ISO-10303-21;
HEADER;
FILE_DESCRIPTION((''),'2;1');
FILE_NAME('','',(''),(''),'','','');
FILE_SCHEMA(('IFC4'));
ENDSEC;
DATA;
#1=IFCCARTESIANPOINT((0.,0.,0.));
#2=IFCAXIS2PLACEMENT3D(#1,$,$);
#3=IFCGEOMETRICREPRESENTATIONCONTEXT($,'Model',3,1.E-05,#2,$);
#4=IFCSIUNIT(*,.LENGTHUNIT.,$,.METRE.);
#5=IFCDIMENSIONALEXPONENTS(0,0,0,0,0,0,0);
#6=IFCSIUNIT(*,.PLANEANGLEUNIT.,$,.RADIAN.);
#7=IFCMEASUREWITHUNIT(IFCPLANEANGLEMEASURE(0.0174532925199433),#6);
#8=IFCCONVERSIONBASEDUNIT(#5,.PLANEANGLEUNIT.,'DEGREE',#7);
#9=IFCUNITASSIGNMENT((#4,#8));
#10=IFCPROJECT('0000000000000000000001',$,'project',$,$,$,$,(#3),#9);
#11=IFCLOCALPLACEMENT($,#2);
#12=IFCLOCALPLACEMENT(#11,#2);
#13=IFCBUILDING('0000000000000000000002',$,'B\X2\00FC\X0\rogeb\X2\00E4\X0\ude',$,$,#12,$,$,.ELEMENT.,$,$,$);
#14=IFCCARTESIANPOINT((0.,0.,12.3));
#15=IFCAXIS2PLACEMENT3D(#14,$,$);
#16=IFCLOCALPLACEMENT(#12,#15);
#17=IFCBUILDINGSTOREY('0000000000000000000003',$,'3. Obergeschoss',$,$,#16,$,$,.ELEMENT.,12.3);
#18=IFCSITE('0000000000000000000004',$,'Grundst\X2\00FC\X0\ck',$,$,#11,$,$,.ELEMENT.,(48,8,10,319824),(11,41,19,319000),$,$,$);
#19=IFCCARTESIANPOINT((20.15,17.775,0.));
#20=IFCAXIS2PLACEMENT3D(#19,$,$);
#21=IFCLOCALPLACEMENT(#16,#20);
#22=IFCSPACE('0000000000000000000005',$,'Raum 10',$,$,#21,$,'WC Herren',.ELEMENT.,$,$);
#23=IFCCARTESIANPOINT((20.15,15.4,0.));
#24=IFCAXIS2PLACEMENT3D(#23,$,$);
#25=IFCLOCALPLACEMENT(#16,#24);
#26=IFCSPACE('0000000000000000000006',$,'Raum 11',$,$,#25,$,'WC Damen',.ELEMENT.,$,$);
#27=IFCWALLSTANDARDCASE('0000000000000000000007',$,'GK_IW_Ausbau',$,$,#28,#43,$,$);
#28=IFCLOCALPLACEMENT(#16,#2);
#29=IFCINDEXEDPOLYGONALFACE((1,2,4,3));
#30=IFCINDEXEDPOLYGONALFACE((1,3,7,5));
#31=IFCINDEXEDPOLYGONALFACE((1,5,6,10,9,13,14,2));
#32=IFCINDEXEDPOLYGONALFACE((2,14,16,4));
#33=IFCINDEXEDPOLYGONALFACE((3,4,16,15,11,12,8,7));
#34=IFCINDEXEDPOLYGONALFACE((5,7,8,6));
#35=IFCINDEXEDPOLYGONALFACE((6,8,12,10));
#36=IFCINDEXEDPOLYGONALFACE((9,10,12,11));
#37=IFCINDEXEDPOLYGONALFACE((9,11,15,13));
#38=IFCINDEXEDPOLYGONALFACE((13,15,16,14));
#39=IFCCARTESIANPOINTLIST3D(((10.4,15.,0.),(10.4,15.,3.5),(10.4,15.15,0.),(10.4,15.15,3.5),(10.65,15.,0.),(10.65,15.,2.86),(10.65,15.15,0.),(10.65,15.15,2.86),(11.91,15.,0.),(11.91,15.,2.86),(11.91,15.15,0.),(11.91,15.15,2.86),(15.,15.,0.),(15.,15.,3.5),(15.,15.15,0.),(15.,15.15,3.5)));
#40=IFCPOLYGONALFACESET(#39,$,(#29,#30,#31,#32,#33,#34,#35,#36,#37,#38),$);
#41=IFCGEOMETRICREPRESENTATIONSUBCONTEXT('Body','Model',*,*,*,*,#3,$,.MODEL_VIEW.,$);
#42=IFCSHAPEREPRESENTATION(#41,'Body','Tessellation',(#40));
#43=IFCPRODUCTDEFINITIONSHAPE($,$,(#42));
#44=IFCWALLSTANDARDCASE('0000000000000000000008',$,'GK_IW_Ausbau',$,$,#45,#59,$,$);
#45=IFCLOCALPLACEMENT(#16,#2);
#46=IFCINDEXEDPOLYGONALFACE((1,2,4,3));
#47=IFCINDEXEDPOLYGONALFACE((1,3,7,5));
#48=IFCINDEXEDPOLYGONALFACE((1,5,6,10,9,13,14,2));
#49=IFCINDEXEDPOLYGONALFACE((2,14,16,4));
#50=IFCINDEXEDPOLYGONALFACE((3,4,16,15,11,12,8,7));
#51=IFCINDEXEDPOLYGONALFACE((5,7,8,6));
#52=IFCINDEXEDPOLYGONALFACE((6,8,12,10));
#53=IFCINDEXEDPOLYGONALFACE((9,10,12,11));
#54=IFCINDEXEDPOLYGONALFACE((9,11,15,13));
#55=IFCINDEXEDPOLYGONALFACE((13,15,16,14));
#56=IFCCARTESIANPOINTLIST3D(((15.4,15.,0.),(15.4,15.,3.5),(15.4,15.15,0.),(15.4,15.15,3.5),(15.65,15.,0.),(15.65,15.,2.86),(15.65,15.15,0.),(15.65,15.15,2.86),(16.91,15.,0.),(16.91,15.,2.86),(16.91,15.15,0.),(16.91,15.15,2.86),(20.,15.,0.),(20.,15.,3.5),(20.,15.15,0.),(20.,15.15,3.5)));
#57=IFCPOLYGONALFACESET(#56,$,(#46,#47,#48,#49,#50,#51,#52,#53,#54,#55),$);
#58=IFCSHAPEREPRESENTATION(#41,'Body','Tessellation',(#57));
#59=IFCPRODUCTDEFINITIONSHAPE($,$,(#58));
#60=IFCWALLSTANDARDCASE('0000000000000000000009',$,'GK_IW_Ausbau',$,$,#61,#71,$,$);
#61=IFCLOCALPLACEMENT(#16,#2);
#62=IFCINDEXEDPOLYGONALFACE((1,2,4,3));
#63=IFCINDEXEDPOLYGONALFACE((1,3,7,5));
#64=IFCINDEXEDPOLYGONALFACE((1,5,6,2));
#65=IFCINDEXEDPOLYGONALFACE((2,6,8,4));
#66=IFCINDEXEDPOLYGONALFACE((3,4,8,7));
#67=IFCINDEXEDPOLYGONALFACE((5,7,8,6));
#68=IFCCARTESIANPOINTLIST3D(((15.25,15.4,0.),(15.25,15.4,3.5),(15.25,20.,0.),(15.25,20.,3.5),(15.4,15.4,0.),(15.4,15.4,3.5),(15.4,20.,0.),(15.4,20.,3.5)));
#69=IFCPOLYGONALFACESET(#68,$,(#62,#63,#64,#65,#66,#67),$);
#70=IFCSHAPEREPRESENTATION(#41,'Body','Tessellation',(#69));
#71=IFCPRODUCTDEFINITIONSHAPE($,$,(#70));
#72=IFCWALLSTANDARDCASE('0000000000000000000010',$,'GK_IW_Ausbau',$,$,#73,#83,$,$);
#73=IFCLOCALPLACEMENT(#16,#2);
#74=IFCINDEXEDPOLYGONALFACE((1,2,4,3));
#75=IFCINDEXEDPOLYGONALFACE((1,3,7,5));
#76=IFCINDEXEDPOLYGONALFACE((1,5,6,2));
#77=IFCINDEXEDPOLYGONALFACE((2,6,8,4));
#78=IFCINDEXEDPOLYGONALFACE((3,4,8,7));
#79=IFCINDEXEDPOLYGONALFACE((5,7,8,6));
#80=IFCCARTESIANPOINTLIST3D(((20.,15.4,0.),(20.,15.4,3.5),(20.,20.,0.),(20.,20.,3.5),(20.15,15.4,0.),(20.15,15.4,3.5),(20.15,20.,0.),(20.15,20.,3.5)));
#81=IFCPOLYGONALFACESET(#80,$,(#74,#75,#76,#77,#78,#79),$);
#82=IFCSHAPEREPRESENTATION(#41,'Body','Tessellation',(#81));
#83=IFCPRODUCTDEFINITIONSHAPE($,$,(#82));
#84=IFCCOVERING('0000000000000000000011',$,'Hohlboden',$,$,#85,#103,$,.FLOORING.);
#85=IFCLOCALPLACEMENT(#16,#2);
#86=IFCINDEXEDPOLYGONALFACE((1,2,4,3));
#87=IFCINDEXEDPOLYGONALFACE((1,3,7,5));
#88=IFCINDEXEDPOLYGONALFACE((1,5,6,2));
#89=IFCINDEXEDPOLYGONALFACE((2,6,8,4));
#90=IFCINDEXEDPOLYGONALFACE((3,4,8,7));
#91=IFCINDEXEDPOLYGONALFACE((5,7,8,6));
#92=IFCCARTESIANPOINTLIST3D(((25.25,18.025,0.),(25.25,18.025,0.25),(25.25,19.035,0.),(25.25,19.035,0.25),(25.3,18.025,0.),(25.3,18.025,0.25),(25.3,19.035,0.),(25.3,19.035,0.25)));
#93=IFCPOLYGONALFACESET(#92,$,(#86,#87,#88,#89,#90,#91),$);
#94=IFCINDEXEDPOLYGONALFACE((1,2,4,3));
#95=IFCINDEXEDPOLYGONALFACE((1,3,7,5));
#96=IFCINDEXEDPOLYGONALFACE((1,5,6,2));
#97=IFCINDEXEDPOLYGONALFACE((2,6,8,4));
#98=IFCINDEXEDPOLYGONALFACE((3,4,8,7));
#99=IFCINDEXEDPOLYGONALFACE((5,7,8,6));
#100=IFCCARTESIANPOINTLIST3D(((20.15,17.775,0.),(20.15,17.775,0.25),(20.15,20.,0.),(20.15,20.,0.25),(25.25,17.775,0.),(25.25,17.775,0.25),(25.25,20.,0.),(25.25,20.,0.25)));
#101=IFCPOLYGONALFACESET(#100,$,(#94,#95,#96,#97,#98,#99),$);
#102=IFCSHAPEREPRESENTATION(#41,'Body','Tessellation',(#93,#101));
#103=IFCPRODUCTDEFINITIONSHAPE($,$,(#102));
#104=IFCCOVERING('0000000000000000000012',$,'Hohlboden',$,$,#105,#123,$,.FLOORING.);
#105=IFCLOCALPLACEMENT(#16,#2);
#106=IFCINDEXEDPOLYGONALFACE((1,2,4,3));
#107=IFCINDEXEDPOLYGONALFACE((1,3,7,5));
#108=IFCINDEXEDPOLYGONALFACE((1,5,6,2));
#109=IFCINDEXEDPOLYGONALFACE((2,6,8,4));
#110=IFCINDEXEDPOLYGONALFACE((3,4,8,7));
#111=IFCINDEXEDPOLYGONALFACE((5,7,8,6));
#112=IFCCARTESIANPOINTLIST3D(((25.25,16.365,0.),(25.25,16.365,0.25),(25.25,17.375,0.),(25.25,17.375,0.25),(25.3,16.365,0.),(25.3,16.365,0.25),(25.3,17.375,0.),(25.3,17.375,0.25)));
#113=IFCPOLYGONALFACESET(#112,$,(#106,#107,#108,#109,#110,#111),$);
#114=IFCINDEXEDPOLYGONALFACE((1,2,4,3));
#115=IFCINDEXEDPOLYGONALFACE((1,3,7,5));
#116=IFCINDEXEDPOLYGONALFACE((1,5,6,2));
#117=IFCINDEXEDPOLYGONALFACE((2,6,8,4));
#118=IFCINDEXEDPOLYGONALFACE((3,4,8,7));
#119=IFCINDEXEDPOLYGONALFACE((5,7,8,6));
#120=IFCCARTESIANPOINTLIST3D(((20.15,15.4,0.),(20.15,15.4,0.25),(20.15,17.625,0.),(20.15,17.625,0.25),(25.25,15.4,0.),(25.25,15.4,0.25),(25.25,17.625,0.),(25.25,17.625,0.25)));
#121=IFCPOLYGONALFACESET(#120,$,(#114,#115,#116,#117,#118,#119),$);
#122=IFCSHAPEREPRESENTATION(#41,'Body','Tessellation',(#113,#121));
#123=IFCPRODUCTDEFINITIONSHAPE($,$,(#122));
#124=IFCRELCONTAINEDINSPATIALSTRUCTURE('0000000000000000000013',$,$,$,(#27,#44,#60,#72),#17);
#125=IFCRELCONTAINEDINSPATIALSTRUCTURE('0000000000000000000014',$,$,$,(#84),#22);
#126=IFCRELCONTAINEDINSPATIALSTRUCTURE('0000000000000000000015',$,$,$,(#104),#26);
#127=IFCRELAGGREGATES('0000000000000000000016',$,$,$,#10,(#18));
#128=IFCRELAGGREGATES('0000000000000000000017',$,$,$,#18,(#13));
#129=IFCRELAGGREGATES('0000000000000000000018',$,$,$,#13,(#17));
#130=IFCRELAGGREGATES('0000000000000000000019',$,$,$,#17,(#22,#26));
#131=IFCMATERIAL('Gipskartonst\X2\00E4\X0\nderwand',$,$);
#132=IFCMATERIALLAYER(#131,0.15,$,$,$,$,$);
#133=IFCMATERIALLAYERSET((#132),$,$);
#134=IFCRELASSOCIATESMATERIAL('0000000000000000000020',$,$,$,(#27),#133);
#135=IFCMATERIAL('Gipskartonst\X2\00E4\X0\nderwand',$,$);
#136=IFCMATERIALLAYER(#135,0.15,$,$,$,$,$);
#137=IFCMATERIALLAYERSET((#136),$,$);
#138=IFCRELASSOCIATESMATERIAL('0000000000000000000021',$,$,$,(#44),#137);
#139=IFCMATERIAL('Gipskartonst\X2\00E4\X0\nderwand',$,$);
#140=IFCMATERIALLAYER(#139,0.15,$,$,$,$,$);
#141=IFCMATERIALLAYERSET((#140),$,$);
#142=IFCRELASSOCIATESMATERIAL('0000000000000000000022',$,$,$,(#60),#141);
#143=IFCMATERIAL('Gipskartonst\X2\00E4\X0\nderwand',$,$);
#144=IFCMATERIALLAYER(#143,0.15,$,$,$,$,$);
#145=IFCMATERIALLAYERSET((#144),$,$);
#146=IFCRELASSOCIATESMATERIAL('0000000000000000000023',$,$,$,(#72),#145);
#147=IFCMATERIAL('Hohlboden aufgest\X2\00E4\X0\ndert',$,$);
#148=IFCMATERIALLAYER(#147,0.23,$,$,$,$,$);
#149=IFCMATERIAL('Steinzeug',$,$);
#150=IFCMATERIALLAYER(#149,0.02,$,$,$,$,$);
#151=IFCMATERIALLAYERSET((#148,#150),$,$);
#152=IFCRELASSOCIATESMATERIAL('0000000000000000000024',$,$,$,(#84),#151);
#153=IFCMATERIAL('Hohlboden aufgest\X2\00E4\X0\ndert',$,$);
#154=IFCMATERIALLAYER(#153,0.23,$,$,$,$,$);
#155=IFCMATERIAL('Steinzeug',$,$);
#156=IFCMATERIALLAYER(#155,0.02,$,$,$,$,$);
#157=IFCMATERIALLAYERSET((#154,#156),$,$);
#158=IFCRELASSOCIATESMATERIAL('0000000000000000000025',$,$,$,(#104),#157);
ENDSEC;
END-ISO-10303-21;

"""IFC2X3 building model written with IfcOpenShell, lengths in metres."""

from ifc_helpers import new_model, entity, si_unit, converted_unit, frame, frame_2d, origin, origin_with_axes, place, context, subcontext, project, spatial, polyline, rectangle, outline, extrude, material, layer, layer_set, layer_usage, element, save


model = new_model("IFC2X3")

# Units and contexts
model_context = context("Model", 3, precision=1e-05, world=origin())
body_context = subcontext(model_context, "Body", "Model", "MODEL_VIEW")
ifc_project = project(units=[si_unit("LENGTHUNIT", "METRE"), converted_unit("PLANEANGLEUNIT", "DEGREE", entity("IfcPlaneAngleMeasure", 0.0174532925199433), si_unit("PLANEANGLEUNIT", "RADIAN"), dimensions=[0, 0, 0, 0, 0, 0, 0])], contexts=[model_context])

# Site, building, storey
site_placement = place(None, origin())
site = spatial("IfcSite", under=ifc_project, at=site_placement, Name="Grundstück", CompositionType="ELEMENT", RefLatitude=(48, 8, 10, 319824), RefLongitude=(11, 41, 19, 319000))
building_placement = place(site_placement, origin())
building = spatial("IfcBuilding", under=site, at=building_placement, Name="Bürogebäude", CompositionType="ELEMENT")
storey_placement = place(building_placement, frame((0.0, 0.0, 12.3)))
storey = spatial("IfcBuildingStorey", under=building, at=storey_placement, Name="3. Obergeschoss", CompositionType="ELEMENT", Elevation=12.3)

# Walls, openings
ifc_material_1 = material(Name="Gipskartonständerwand")
ifc_layer_1 = layer(ifc_material_1, 0.15)
ifc_layer_set_1 = layer_set([ifc_layer_1])
ifc_layer_usage_1 = layer_usage(ifc_layer_set_1, "AXIS2", "POSITIVE", -0.15)
wall_1_placement = place(storey_placement, frame((15.0, 15.15, 0.0), z_axis=(0.0, 0.0, 1.0), x_axis=(-1.0, 0.0, 0.0)))
wall_1 = element("IfcWallStandardCase", 1, at=wall_1_placement, inside=storey, material=ifc_layer_usage_1, Name="GK_IW_Ausbau", context=body_context, shape_type="SweptSolid", body=[
    extrude(rectangle(XDim=4.6, YDim=0.15, at=frame_2d((2.3, 0.075), x_axis=(1.0, 0.0))), origin_with_axes(), (0.0, 0.0, 1.0), 3.5),
])
opening_1_placement = place(wall_1_placement, frame((4.35, 0.15, 0.0), z_axis=(0.0, -1.0, 0.0), x_axis=(0.0, 0.0, 1.0)))
element("IfcOpeningElement", 2, at=opening_1_placement, cuts=wall_1, ObjectType="Opening", context=body_context, shape_type="SweptSolid", body=[
    extrude(outline(polyline([(0.0, 1.26), (2.86, 1.26), (2.86, 0.0), (0.0, 0.0), (0.0, 1.26)])), origin_with_axes(), (0.0, 0.0, 1.0), 0.15),
])
ifc_material_2 = material(Name="Gipskartonständerwand")
ifc_layer_2 = layer(ifc_material_2, 0.15)
ifc_layer_set_2 = layer_set([ifc_layer_2])
ifc_layer_usage_2 = layer_usage(ifc_layer_set_2, "AXIS2", "POSITIVE", -0.15)
wall_2_placement = place(storey_placement, frame((20.0, 15.15, 0.0), z_axis=(0.0, 0.0, 1.0), x_axis=(-1.0, 0.0, 0.0)))
wall_2 = element("IfcWallStandardCase", 3, at=wall_2_placement, inside=storey, material=ifc_layer_usage_2, Name="GK_IW_Ausbau", context=body_context, shape_type="SweptSolid", body=[
    extrude(rectangle(XDim=4.6, YDim=0.15, at=frame_2d((2.3, 0.075), x_axis=(1.0, 0.0))), origin_with_axes(), (0.0, 0.0, 1.0), 3.5),
])
opening_2_placement = place(wall_2_placement, frame((4.35, 0.15, 0.0), z_axis=(0.0, -1.0, 0.0), x_axis=(0.0, 0.0, 1.0)))
element("IfcOpeningElement", 4, at=opening_2_placement, cuts=wall_2, ObjectType="Opening", context=body_context, shape_type="SweptSolid", body=[
    extrude(outline(polyline([(0.0, 1.26), (2.86, 1.26), (2.86, 0.0), (0.0, 0.0), (0.0, 1.26)])), origin_with_axes(), (0.0, 0.0, 1.0), 0.15),
])

# Walls
ifc_material_3 = material(Name="Gipskartonständerwand")
ifc_layer_3 = layer(ifc_material_3, 0.15)
ifc_layer_set_3 = layer_set([ifc_layer_3])
ifc_layer_usage_3 = layer_usage(ifc_layer_set_3, "AXIS2", "POSITIVE", -0.15)
wall_3_placement = place(storey_placement, frame((15.25, 20.0, 0.0), z_axis=(0.0, 0.0, 1.0), x_axis=(0.0, -1.0, 0.0)))
element("IfcWallStandardCase", 5, at=wall_3_placement, inside=storey, material=ifc_layer_usage_3, Name="GK_IW_Ausbau", context=body_context, shape_type="SweptSolid", body=[
    extrude(rectangle(XDim=4.6, YDim=0.15, at=frame_2d((2.3, 0.075), x_axis=(1.0, 0.0))), origin_with_axes(), (0.0, 0.0, 1.0), 3.5),
])
ifc_material_4 = material(Name="Gipskartonständerwand")
ifc_layer_4 = layer(ifc_material_4, 0.15)
ifc_layer_set_4 = layer_set([ifc_layer_4])
ifc_layer_usage_4 = layer_usage(ifc_layer_set_4, "AXIS2", "POSITIVE", -0.15)
wall_4_placement = place(storey_placement, frame((20.15, 15.4, 0.0), z_axis=(0.0, 0.0, 1.0), x_axis=(0.0, 1.0, 0.0)))
element("IfcWallStandardCase", 6, at=wall_4_placement, inside=storey, material=ifc_layer_usage_4, Name="GK_IW_Ausbau", context=body_context, shape_type="SweptSolid", body=[
    extrude(rectangle(XDim=4.6, YDim=0.15, at=frame_2d((2.3, 0.075), x_axis=(1.0, 0.0))), origin_with_axes(), (0.0, 0.0, 1.0), 3.5),
])

# Shared definitions
space_1_placement = place(storey_placement, frame((20.15, 17.775, 0.0)))
space_1 = spatial("IfcSpace", under=storey, at=space_1_placement, Name="Raum 10", LongName="WC Herren", CompositionType="ELEMENT")

# Covering
ifc_material_5 = material(Name="Hohlboden aufgeständert")
ifc_layer_5 = layer(ifc_material_5, 0.23)
ifc_material_6 = material(Name="Steinzeug")
ifc_layer_6 = layer(ifc_material_6, 0.02)
ifc_layer_set_5 = layer_set([ifc_layer_5, ifc_layer_6])
ifc_layer_usage_5 = layer_usage(ifc_layer_set_5, "AXIS3", "POSITIVE", 0.0)
covering_1_placement = place(storey_placement, frame((20.15, 17.775, 0.0)))
element("IfcCovering", 7, at=covering_1_placement, inside=space_1, material=ifc_layer_usage_5, Name="Hohlboden", PredefinedType="FLOORING", context=body_context, shape_type="SweptSolid", body=[
    extrude(rectangle(XDim=0.05, YDim=1.01, at=frame_2d((0.025, 0.505), x_axis=(1.0, 0.0))), frame((5.1, 0.25, 0.0), z_axis=(0.0, 0.0, 1.0), x_axis=(1.0, 0.0, 0.0)), (0.0, 0.0, 1.0), 0.25),
    extrude(rectangle(XDim=5.1, YDim=2.225, at=frame_2d((-2.55, -1.1125), x_axis=(-1.0, 0.0))), frame((5.1, 2.225, 0.0), z_axis=(0.0, 0.0, 1.0), x_axis=(1.0, 0.0, 0.0)), (0.0, 0.0, 1.0), 0.25),
])

# Shared definitions
space_2_placement = place(storey_placement, frame((20.15, 15.4, 0.0)))
space_2 = spatial("IfcSpace", under=storey, at=space_2_placement, Name="Raum 11", LongName="WC Damen", CompositionType="ELEMENT")

# Covering
ifc_material_7 = material(Name="Hohlboden aufgeständert")
ifc_layer_7 = layer(ifc_material_7, 0.23)
ifc_material_8 = material(Name="Steinzeug")
ifc_layer_8 = layer(ifc_material_8, 0.02)
ifc_layer_set_6 = layer_set([ifc_layer_7, ifc_layer_8])
ifc_layer_usage_6 = layer_usage(ifc_layer_set_6, "AXIS3", "POSITIVE", 0.0)
covering_2_placement = place(storey_placement, frame((20.15, 15.4, 0.0)))
element("IfcCovering", 8, at=covering_2_placement, inside=space_2, material=ifc_layer_usage_6, Name="Hohlboden", PredefinedType="FLOORING", context=body_context, shape_type="SweptSolid", body=[
    extrude(rectangle(XDim=0.05, YDim=1.01, at=frame_2d((0.025, 0.505), x_axis=(1.0, 0.0))), frame((5.1, 0.965, 0.0), z_axis=(0.0, 0.0, 1.0), x_axis=(1.0, 0.0, 0.0)), (0.0, 0.0, 1.0), 0.25),
    extrude(rectangle(XDim=2.225, YDim=5.1, at=frame_2d((2.55, -1.1125), x_axis=(0.0, -1.0))), frame((0.0, 2.225, 0.0), z_axis=(0.0, 0.0, 1.0), x_axis=(1.0, 0.0, 0.0)), (0.0, 0.0, 1.0), 0.25),
])

save(model, "model.ifc")
